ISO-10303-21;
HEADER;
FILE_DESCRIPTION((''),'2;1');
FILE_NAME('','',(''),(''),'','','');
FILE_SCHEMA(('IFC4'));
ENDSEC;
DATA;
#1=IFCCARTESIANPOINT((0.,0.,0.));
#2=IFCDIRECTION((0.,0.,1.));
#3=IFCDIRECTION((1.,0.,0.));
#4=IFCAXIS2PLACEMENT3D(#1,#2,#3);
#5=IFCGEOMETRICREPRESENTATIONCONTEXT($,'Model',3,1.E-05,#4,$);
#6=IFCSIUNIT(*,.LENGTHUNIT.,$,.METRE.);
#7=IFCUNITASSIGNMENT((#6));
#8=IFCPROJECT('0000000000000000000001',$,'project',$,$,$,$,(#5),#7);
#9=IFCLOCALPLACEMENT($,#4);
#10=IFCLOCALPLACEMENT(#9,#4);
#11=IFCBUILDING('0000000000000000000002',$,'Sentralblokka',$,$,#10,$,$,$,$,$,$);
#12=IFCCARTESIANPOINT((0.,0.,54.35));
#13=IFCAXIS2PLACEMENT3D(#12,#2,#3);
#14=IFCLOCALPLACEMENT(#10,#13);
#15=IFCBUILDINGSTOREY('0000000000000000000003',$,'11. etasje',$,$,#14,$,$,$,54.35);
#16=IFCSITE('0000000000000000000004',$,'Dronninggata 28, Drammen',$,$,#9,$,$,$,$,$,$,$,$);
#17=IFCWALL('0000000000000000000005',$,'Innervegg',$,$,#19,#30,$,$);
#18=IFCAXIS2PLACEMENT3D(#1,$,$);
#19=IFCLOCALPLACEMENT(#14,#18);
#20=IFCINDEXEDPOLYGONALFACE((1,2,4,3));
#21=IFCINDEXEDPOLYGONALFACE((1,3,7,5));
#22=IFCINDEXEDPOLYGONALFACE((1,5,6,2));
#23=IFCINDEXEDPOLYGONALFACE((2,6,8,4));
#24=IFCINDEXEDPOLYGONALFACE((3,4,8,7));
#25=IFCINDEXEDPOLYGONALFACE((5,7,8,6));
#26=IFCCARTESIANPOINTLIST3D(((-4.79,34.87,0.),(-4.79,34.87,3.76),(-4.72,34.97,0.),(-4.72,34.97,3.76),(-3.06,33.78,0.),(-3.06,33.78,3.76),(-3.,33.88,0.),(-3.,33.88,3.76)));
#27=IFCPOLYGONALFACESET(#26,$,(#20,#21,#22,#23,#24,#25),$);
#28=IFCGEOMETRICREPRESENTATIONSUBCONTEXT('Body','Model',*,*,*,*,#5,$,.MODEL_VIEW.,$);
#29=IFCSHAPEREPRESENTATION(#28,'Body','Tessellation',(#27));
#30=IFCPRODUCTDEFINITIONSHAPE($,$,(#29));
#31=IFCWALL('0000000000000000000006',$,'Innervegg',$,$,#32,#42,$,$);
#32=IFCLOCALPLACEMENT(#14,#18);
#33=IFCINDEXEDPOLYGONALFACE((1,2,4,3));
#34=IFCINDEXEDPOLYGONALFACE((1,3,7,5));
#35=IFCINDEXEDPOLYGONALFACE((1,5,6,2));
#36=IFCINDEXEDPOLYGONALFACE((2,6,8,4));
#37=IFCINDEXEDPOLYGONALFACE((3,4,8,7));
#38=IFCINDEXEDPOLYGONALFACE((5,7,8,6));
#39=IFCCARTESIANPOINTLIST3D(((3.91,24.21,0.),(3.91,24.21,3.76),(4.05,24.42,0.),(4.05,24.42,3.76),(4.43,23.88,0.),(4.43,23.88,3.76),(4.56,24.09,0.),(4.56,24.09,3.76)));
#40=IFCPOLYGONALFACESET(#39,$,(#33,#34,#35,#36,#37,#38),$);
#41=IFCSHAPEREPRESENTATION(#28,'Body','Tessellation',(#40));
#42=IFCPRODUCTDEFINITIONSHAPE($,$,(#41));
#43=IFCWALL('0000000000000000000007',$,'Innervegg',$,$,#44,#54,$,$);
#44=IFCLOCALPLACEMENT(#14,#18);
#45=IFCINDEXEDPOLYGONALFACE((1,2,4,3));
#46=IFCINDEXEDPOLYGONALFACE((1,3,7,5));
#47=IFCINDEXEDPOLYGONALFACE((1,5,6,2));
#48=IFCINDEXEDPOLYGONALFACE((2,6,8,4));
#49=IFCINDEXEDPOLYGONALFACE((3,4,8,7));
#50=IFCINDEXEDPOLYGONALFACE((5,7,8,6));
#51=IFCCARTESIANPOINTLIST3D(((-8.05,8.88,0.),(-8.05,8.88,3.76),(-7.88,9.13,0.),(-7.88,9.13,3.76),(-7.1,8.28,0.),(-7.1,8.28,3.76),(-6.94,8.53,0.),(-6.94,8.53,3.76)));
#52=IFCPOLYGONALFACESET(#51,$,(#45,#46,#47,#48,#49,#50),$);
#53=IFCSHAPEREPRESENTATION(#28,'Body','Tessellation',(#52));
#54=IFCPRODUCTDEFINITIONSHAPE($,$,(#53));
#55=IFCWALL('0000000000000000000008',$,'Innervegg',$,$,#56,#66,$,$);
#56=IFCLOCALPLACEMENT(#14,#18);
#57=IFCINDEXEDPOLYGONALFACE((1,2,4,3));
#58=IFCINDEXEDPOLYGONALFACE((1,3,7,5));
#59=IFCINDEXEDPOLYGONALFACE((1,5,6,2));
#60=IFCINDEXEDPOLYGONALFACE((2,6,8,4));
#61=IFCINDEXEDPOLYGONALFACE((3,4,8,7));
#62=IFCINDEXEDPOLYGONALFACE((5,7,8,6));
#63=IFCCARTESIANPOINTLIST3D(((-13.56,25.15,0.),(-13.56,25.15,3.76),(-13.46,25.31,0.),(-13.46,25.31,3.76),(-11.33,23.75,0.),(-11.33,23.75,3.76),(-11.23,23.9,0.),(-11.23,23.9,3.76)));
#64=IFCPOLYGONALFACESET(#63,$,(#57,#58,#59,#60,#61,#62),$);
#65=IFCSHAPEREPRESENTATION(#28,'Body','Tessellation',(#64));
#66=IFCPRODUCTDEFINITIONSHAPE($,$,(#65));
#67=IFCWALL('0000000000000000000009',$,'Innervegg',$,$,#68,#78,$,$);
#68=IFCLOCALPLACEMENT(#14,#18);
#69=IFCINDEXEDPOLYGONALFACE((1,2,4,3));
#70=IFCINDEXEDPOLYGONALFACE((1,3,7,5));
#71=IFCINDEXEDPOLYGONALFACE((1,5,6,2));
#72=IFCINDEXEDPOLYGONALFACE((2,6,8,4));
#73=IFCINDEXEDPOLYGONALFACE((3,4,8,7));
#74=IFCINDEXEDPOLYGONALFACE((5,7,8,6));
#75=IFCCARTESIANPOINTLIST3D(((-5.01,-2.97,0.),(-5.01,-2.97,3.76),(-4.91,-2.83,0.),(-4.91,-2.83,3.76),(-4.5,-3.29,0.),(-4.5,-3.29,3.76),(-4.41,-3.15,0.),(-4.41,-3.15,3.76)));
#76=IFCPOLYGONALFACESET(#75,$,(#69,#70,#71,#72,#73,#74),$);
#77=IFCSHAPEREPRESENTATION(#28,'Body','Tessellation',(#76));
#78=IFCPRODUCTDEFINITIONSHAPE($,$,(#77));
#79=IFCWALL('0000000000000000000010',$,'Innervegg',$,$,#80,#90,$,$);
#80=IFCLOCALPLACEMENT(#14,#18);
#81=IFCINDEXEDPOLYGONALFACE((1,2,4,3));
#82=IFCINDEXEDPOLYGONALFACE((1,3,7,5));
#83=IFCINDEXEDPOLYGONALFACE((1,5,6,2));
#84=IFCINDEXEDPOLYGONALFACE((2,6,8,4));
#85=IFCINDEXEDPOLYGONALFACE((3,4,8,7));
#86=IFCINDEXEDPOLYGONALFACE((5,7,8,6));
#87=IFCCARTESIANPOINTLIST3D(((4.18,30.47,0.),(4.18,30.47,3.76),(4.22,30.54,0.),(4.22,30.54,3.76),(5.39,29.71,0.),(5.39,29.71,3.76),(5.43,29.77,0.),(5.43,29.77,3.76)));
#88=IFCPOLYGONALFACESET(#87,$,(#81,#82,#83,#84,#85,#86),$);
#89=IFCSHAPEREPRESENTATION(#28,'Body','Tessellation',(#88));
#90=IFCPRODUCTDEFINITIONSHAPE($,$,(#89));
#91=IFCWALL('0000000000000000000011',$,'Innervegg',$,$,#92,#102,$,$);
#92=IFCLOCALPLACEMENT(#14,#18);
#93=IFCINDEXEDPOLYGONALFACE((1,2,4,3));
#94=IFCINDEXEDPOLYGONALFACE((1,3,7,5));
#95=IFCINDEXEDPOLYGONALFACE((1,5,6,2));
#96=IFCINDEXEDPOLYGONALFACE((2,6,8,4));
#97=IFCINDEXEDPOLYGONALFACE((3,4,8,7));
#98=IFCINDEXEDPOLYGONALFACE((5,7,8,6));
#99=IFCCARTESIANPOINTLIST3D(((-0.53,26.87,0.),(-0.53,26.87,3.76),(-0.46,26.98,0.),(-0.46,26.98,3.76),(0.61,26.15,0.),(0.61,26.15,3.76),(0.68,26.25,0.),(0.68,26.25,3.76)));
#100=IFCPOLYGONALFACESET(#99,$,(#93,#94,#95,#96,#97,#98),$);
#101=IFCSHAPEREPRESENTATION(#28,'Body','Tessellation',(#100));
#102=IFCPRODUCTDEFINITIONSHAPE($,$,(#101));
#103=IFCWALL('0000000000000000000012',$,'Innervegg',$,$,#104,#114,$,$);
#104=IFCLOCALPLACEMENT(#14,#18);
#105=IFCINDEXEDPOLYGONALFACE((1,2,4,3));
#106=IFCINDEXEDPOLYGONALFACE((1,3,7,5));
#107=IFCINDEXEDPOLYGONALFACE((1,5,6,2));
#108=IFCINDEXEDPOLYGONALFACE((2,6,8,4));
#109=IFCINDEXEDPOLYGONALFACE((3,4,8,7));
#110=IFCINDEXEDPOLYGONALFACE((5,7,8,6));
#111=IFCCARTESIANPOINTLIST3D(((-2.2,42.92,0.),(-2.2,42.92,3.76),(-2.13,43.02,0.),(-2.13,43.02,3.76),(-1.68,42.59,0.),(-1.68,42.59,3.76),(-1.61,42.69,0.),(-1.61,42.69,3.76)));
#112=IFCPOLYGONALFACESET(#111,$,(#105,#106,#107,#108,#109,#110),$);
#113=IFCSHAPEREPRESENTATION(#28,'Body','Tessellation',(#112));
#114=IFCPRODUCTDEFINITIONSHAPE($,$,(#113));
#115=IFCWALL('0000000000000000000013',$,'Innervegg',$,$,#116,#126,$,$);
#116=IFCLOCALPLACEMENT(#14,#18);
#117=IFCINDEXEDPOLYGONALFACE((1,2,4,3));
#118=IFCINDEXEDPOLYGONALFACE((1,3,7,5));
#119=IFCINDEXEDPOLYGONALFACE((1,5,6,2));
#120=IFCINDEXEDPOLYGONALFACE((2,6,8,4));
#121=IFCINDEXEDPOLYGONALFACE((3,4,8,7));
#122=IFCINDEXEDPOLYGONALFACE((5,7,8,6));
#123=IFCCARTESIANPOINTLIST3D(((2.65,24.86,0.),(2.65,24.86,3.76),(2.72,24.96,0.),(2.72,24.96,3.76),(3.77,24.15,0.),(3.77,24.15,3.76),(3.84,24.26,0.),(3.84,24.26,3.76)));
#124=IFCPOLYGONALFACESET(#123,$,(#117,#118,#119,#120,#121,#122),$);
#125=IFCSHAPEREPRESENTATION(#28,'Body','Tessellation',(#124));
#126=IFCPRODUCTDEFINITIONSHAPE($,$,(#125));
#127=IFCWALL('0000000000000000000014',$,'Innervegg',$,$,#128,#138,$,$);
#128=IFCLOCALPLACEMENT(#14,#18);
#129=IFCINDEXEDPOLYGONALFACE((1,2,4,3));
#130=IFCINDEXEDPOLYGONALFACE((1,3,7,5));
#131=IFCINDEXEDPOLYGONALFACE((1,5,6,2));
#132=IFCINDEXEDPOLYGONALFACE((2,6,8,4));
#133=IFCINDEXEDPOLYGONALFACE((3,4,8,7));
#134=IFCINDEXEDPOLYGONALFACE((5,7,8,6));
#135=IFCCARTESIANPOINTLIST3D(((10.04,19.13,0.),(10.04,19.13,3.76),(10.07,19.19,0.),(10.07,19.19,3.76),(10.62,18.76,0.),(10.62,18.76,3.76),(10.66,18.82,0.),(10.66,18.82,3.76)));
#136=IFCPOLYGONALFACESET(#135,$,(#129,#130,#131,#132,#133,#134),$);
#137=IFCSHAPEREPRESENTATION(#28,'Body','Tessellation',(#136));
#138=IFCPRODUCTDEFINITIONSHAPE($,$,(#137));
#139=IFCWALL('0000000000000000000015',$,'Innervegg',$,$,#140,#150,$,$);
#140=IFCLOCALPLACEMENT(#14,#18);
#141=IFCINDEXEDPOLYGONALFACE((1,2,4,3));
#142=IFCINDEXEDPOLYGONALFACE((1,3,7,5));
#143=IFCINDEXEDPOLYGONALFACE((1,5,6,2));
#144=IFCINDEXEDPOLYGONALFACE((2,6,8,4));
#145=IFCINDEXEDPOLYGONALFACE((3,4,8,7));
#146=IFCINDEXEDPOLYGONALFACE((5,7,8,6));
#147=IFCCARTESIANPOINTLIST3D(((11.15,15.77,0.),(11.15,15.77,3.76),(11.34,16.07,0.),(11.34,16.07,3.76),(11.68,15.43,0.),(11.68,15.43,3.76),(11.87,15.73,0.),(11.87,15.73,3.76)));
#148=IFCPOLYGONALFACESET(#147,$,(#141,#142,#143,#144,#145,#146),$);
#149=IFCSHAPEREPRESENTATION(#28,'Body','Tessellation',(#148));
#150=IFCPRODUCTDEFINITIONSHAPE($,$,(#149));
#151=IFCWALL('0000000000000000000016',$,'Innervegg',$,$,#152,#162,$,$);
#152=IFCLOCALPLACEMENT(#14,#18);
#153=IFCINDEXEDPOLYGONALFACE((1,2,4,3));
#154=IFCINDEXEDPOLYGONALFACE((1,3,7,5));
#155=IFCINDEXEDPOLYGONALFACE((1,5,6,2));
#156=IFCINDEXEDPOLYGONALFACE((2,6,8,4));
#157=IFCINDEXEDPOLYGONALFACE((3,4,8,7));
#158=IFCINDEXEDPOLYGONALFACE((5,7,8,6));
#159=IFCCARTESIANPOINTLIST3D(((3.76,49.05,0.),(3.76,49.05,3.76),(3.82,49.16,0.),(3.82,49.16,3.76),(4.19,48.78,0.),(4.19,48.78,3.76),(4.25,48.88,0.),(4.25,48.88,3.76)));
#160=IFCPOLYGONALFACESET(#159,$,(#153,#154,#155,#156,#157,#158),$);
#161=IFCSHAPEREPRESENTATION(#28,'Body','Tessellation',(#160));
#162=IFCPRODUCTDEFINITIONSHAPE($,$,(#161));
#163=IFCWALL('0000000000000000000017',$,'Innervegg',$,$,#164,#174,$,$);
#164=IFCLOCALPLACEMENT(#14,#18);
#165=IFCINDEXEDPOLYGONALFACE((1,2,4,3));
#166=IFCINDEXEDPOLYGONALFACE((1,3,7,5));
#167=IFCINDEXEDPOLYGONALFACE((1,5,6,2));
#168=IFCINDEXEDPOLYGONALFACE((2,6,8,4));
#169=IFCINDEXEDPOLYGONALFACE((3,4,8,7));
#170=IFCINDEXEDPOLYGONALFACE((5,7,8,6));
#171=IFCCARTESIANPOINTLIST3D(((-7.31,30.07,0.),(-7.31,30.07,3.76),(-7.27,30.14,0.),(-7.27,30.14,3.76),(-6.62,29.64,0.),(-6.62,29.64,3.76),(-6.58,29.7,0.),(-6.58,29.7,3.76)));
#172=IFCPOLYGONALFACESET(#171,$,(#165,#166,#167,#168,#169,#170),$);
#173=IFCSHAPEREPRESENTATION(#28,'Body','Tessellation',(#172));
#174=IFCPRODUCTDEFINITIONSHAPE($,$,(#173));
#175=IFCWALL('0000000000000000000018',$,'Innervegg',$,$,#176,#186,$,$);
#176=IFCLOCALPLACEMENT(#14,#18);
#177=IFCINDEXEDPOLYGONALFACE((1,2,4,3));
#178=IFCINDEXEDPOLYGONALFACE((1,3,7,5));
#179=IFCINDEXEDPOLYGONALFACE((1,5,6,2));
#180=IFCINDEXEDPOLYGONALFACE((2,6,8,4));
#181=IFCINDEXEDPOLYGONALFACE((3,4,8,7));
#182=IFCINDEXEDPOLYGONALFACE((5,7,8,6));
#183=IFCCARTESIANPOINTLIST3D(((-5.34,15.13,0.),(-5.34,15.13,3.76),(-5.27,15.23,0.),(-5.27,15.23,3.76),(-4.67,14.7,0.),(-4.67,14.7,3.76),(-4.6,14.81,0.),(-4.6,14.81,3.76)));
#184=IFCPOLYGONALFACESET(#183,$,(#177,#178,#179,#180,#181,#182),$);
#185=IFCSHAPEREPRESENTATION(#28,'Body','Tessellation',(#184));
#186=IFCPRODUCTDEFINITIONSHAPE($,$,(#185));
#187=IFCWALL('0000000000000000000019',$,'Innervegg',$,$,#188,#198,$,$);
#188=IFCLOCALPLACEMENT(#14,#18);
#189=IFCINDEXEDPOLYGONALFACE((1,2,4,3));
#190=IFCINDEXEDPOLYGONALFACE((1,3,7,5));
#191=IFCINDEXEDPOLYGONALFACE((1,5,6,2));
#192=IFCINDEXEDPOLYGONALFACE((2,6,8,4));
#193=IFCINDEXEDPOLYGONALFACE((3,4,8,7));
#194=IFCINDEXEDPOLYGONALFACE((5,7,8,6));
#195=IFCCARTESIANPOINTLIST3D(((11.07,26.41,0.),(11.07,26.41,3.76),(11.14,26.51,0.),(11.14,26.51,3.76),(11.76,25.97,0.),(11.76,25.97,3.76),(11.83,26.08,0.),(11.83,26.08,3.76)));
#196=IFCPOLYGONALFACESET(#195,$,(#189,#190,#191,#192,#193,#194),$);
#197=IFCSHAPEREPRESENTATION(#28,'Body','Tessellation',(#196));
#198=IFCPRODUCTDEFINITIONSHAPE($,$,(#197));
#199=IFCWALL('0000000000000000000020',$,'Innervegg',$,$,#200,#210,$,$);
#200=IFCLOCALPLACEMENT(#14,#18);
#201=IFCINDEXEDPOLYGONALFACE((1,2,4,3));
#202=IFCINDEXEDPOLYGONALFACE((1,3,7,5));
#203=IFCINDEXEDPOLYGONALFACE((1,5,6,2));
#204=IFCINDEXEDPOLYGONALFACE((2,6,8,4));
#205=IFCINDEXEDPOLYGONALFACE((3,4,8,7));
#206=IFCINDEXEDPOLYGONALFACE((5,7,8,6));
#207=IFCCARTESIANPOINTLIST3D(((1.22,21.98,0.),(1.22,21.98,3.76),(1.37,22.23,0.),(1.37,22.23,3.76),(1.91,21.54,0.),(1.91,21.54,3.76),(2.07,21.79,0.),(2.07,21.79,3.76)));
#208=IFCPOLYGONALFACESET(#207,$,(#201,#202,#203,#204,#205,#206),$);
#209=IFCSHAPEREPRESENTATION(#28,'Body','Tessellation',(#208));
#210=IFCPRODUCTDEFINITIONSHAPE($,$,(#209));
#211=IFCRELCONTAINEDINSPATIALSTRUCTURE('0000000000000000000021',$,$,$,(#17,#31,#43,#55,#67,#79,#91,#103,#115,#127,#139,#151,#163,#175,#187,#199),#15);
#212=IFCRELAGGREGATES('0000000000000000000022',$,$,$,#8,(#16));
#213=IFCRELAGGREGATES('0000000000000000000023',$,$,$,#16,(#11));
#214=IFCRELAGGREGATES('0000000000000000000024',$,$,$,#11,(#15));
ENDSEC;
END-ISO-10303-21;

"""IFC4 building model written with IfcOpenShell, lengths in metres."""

from ifc_helpers import new_model, si_unit, frame, origin_with_axes, place, context, subcontext, project, spatial, polyline, outline, extrude, element, save


model = new_model("IFC4")

# Units and contexts
model_context = context("Model", 3, precision=1e-05, world=origin_with_axes())
body_context = subcontext(model_context, "Body", "Model", "MODEL_VIEW")
ifc_project = project(units=[si_unit("LENGTHUNIT", "METRE")], contexts=[model_context])

# Site, building, storey
site_placement = place(None, origin_with_axes())
site = spatial("IfcSite", under=ifc_project, at=site_placement, Name="Dronninggata 28, Drammen")
building_placement = place(site_placement, origin_with_axes())
building = spatial("IfcBuilding", under=site, at=building_placement, Name="Sentralblokka")
storey_placement = place(building_placement, frame((0.0, 0.0, 54.35), z_axis=(0.0, 0.0, 1.0), x_axis=(1.0, 0.0, 0.0)))
storey = spatial("IfcBuildingStorey", under=building, at=storey_placement, Name="11. etasje", Elevation=54.35)

# Walls
wall_1_placement = place(storey_placement, frame((0.0, 0.0, -54.35), z_axis=(0.0, 0.0, 1.0), x_axis=(1.0, 0.0, 0.0)))
element("IfcWall", 1, at=wall_1_placement, inside=storey, Name="Innervegg", context=body_context, shape_type="SweptSolid", body=[
    extrude(outline(polyline([(-3.0, 33.88), (-3.06, 33.78), (-4.79, 34.87), (-4.72, 34.97), (-3.0, 33.88)])), frame((0.0, 0.0, 54.35)), (0.0, 0.0, 1.0), 3.76),
])
wall_2_placement = place(storey_placement, frame((0.0, 0.0, -54.35), z_axis=(0.0, 0.0, 1.0), x_axis=(1.0, 0.0, 0.0)))
element("IfcWall", 2, at=wall_2_placement, inside=storey, Name="Innervegg", context=body_context, shape_type="SweptSolid", body=[
    extrude(outline(polyline([(4.56, 24.09), (4.43, 23.88), (3.91, 24.21), (4.05, 24.42), (4.56, 24.09)])), frame((0.0, 0.0, 54.35)), (0.0, 0.0, 1.0), 3.76),
])
wall_3_placement = place(storey_placement, frame((0.0, 0.0, -54.35), z_axis=(0.0, 0.0, 1.0), x_axis=(1.0, 0.0, 0.0)))
element("IfcWall", 3, at=wall_3_placement, inside=storey, Name="Innervegg", context=body_context, shape_type="SweptSolid", body=[
    extrude(outline(polyline([(-6.94, 8.53), (-7.1, 8.28), (-8.05, 8.88), (-7.88, 9.13), (-6.94, 8.53)])), frame((0.0, 0.0, 54.35)), (0.0, 0.0, 1.0), 3.76),
])
wall_4_placement = place(storey_placement, frame((0.0, 0.0, -54.35), z_axis=(0.0, 0.0, 1.0), x_axis=(1.0, 0.0, 0.0)))
element("IfcWall", 4, at=wall_4_placement, inside=storey, Name="Innervegg", context=body_context, shape_type="SweptSolid", body=[
    extrude(outline(polyline([(-11.23, 23.9), (-11.33, 23.75), (-13.56, 25.15), (-13.46, 25.31), (-11.23, 23.9)])), frame((0.0, 0.0, 54.35)), (0.0, 0.0, 1.0), 3.76),
])
wall_5_placement = place(storey_placement, frame((0.0, 0.0, -54.35), z_axis=(0.0, 0.0, 1.0), x_axis=(1.0, 0.0, 0.0)))
element("IfcWall", 5, at=wall_5_placement, inside=storey, Name="Innervegg", context=body_context, shape_type="SweptSolid", body=[
    extrude(outline(polyline([(-4.41, -3.15), (-4.5, -3.29), (-5.01, -2.97), (-4.91, -2.83), (-4.41, -3.15)])), frame((0.0, 0.0, 54.35)), (0.0, 0.0, 1.0), 3.76),
])
wall_6_placement = place(storey_placement, frame((0.0, 0.0, -54.35), z_axis=(0.0, 0.0, 1.0), x_axis=(1.0, 0.0, 0.0)))
element("IfcWall", 6, at=wall_6_placement, inside=storey, Name="Innervegg", context=body_context, shape_type="SweptSolid", body=[
    extrude(outline(polyline([(5.43, 29.77), (5.39, 29.71), (4.18, 30.47), (4.22, 30.54), (5.43, 29.77)])), frame((0.0, 0.0, 54.35)), (0.0, 0.0, 1.0), 3.76),
])
wall_7_placement = place(storey_placement, frame((0.0, 0.0, -54.35), z_axis=(0.0, 0.0, 1.0), x_axis=(1.0, 0.0, 0.0)))
element("IfcWall", 7, at=wall_7_placement, inside=storey, Name="Innervegg", context=body_context, shape_type="SweptSolid", body=[
    extrude(outline(polyline([(0.68, 26.25), (0.61, 26.15), (-0.53, 26.87), (-0.46, 26.98), (0.68, 26.25)])), frame((0.0, 0.0, 54.35)), (0.0, 0.0, 1.0), 3.76),
])
wall_8_placement = place(storey_placement, frame((0.0, 0.0, -54.35), z_axis=(0.0, 0.0, 1.0), x_axis=(1.0, 0.0, 0.0)))
element("IfcWall", 8, at=wall_8_placement, inside=storey, Name="Innervegg", context=body_context, shape_type="SweptSolid", body=[
    extrude(outline(polyline([(-1.61, 42.69), (-1.68, 42.59), (-2.2, 42.92), (-2.13, 43.02), (-1.61, 42.69)])), frame((0.0, 0.0, 54.35)), (0.0, 0.0, 1.0), 3.76),
])
wall_9_placement = place(storey_placement, frame((0.0, 0.0, -54.35), z_axis=(0.0, 0.0, 1.0), x_axis=(1.0, 0.0, 0.0)))
element("IfcWall", 9, at=wall_9_placement, inside=storey, Name="Innervegg", context=body_context, shape_type="SweptSolid", body=[
    extrude(outline(polyline([(3.84, 24.26), (3.77, 24.15), (2.65, 24.86), (2.72, 24.96), (3.84, 24.26)])), frame((0.0, 0.0, 54.35)), (0.0, 0.0, 1.0), 3.76),
])
wall_10_placement = place(storey_placement, frame((0.0, 0.0, -54.35), z_axis=(0.0, 0.0, 1.0), x_axis=(1.0, 0.0, 0.0)))
element("IfcWall", 10, at=wall_10_placement, inside=storey, Name="Innervegg", context=body_context, shape_type="SweptSolid", body=[
    extrude(outline(polyline([(10.66, 18.82), (10.62, 18.76), (10.04, 19.13), (10.07, 19.19), (10.66, 18.82)])), frame((0.0, 0.0, 54.35)), (0.0, 0.0, 1.0), 3.76),
])
wall_11_placement = place(storey_placement, frame((0.0, 0.0, -54.35), z_axis=(0.0, 0.0, 1.0), x_axis=(1.0, 0.0, 0.0)))
element("IfcWall", 11, at=wall_11_placement, inside=storey, Name="Innervegg", context=body_context, shape_type="SweptSolid", body=[
    extrude(outline(polyline([(11.87, 15.73), (11.68, 15.43), (11.15, 15.77), (11.34, 16.07), (11.87, 15.73)])), frame((0.0, 0.0, 54.35)), (0.0, 0.0, 1.0), 3.76),
])
wall_12_placement = place(storey_placement, frame((0.0, 0.0, -54.35), z_axis=(0.0, 0.0, 1.0), x_axis=(1.0, 0.0, 0.0)))
element("IfcWall", 12, at=wall_12_placement, inside=storey, Name="Innervegg", context=body_context, shape_type="SweptSolid", body=[
    extrude(outline(polyline([(4.25, 48.88), (4.19, 48.78), (3.76, 49.05), (3.82, 49.16), (4.25, 48.88)])), frame((0.0, 0.0, 54.35)), (0.0, 0.0, 1.0), 3.76),
])
wall_13_placement = place(storey_placement, frame((0.0, 0.0, -54.35), z_axis=(0.0, 0.0, 1.0), x_axis=(1.0, 0.0, 0.0)))
element("IfcWall", 13, at=wall_13_placement, inside=storey, Name="Innervegg", context=body_context, shape_type="SweptSolid", body=[
    extrude(outline(polyline([(-6.58, 29.7), (-6.62, 29.64), (-7.31, 30.07), (-7.27, 30.14), (-6.58, 29.7)])), frame((0.0, 0.0, 54.35)), (0.0, 0.0, 1.0), 3.76),
])
wall_14_placement = place(storey_placement, frame((0.0, 0.0, -54.35), z_axis=(0.0, 0.0, 1.0), x_axis=(1.0, 0.0, 0.0)))
element("IfcWall", 14, at=wall_14_placement, inside=storey, Name="Innervegg", context=body_context, shape_type="SweptSolid", body=[
    extrude(outline(polyline([(-4.6, 14.81), (-4.67, 14.7), (-5.34, 15.13), (-5.27, 15.23), (-4.6, 14.81)])), frame((0.0, 0.0, 54.35)), (0.0, 0.0, 1.0), 3.76),
])
wall_15_placement = place(storey_placement, frame((0.0, 0.0, -54.35), z_axis=(0.0, 0.0, 1.0), x_axis=(1.0, 0.0, 0.0)))
element("IfcWall", 15, at=wall_15_placement, inside=storey, Name="Innervegg", context=body_context, shape_type="SweptSolid", body=[
    extrude(outline(polyline([(11.83, 26.08), (11.76, 25.97), (11.07, 26.41), (11.14, 26.51), (11.83, 26.08)])), frame((0.0, 0.0, 54.35)), (0.0, 0.0, 1.0), 3.76),
])
wall_16_placement = place(storey_placement, frame((0.0, 0.0, -54.35), z_axis=(0.0, 0.0, 1.0), x_axis=(1.0, 0.0, 0.0)))
element("IfcWall", 16, at=wall_16_placement, inside=storey, Name="Innervegg", context=body_context, shape_type="SweptSolid", body=[
    extrude(outline(polyline([(2.07, 21.79), (1.91, 21.54), (1.22, 21.98), (1.37, 22.23), (2.07, 21.79)])), frame((0.0, 0.0, 54.35)), (0.0, 0.0, 1.0), 3.76),
])

save(model, "model.ifc")
